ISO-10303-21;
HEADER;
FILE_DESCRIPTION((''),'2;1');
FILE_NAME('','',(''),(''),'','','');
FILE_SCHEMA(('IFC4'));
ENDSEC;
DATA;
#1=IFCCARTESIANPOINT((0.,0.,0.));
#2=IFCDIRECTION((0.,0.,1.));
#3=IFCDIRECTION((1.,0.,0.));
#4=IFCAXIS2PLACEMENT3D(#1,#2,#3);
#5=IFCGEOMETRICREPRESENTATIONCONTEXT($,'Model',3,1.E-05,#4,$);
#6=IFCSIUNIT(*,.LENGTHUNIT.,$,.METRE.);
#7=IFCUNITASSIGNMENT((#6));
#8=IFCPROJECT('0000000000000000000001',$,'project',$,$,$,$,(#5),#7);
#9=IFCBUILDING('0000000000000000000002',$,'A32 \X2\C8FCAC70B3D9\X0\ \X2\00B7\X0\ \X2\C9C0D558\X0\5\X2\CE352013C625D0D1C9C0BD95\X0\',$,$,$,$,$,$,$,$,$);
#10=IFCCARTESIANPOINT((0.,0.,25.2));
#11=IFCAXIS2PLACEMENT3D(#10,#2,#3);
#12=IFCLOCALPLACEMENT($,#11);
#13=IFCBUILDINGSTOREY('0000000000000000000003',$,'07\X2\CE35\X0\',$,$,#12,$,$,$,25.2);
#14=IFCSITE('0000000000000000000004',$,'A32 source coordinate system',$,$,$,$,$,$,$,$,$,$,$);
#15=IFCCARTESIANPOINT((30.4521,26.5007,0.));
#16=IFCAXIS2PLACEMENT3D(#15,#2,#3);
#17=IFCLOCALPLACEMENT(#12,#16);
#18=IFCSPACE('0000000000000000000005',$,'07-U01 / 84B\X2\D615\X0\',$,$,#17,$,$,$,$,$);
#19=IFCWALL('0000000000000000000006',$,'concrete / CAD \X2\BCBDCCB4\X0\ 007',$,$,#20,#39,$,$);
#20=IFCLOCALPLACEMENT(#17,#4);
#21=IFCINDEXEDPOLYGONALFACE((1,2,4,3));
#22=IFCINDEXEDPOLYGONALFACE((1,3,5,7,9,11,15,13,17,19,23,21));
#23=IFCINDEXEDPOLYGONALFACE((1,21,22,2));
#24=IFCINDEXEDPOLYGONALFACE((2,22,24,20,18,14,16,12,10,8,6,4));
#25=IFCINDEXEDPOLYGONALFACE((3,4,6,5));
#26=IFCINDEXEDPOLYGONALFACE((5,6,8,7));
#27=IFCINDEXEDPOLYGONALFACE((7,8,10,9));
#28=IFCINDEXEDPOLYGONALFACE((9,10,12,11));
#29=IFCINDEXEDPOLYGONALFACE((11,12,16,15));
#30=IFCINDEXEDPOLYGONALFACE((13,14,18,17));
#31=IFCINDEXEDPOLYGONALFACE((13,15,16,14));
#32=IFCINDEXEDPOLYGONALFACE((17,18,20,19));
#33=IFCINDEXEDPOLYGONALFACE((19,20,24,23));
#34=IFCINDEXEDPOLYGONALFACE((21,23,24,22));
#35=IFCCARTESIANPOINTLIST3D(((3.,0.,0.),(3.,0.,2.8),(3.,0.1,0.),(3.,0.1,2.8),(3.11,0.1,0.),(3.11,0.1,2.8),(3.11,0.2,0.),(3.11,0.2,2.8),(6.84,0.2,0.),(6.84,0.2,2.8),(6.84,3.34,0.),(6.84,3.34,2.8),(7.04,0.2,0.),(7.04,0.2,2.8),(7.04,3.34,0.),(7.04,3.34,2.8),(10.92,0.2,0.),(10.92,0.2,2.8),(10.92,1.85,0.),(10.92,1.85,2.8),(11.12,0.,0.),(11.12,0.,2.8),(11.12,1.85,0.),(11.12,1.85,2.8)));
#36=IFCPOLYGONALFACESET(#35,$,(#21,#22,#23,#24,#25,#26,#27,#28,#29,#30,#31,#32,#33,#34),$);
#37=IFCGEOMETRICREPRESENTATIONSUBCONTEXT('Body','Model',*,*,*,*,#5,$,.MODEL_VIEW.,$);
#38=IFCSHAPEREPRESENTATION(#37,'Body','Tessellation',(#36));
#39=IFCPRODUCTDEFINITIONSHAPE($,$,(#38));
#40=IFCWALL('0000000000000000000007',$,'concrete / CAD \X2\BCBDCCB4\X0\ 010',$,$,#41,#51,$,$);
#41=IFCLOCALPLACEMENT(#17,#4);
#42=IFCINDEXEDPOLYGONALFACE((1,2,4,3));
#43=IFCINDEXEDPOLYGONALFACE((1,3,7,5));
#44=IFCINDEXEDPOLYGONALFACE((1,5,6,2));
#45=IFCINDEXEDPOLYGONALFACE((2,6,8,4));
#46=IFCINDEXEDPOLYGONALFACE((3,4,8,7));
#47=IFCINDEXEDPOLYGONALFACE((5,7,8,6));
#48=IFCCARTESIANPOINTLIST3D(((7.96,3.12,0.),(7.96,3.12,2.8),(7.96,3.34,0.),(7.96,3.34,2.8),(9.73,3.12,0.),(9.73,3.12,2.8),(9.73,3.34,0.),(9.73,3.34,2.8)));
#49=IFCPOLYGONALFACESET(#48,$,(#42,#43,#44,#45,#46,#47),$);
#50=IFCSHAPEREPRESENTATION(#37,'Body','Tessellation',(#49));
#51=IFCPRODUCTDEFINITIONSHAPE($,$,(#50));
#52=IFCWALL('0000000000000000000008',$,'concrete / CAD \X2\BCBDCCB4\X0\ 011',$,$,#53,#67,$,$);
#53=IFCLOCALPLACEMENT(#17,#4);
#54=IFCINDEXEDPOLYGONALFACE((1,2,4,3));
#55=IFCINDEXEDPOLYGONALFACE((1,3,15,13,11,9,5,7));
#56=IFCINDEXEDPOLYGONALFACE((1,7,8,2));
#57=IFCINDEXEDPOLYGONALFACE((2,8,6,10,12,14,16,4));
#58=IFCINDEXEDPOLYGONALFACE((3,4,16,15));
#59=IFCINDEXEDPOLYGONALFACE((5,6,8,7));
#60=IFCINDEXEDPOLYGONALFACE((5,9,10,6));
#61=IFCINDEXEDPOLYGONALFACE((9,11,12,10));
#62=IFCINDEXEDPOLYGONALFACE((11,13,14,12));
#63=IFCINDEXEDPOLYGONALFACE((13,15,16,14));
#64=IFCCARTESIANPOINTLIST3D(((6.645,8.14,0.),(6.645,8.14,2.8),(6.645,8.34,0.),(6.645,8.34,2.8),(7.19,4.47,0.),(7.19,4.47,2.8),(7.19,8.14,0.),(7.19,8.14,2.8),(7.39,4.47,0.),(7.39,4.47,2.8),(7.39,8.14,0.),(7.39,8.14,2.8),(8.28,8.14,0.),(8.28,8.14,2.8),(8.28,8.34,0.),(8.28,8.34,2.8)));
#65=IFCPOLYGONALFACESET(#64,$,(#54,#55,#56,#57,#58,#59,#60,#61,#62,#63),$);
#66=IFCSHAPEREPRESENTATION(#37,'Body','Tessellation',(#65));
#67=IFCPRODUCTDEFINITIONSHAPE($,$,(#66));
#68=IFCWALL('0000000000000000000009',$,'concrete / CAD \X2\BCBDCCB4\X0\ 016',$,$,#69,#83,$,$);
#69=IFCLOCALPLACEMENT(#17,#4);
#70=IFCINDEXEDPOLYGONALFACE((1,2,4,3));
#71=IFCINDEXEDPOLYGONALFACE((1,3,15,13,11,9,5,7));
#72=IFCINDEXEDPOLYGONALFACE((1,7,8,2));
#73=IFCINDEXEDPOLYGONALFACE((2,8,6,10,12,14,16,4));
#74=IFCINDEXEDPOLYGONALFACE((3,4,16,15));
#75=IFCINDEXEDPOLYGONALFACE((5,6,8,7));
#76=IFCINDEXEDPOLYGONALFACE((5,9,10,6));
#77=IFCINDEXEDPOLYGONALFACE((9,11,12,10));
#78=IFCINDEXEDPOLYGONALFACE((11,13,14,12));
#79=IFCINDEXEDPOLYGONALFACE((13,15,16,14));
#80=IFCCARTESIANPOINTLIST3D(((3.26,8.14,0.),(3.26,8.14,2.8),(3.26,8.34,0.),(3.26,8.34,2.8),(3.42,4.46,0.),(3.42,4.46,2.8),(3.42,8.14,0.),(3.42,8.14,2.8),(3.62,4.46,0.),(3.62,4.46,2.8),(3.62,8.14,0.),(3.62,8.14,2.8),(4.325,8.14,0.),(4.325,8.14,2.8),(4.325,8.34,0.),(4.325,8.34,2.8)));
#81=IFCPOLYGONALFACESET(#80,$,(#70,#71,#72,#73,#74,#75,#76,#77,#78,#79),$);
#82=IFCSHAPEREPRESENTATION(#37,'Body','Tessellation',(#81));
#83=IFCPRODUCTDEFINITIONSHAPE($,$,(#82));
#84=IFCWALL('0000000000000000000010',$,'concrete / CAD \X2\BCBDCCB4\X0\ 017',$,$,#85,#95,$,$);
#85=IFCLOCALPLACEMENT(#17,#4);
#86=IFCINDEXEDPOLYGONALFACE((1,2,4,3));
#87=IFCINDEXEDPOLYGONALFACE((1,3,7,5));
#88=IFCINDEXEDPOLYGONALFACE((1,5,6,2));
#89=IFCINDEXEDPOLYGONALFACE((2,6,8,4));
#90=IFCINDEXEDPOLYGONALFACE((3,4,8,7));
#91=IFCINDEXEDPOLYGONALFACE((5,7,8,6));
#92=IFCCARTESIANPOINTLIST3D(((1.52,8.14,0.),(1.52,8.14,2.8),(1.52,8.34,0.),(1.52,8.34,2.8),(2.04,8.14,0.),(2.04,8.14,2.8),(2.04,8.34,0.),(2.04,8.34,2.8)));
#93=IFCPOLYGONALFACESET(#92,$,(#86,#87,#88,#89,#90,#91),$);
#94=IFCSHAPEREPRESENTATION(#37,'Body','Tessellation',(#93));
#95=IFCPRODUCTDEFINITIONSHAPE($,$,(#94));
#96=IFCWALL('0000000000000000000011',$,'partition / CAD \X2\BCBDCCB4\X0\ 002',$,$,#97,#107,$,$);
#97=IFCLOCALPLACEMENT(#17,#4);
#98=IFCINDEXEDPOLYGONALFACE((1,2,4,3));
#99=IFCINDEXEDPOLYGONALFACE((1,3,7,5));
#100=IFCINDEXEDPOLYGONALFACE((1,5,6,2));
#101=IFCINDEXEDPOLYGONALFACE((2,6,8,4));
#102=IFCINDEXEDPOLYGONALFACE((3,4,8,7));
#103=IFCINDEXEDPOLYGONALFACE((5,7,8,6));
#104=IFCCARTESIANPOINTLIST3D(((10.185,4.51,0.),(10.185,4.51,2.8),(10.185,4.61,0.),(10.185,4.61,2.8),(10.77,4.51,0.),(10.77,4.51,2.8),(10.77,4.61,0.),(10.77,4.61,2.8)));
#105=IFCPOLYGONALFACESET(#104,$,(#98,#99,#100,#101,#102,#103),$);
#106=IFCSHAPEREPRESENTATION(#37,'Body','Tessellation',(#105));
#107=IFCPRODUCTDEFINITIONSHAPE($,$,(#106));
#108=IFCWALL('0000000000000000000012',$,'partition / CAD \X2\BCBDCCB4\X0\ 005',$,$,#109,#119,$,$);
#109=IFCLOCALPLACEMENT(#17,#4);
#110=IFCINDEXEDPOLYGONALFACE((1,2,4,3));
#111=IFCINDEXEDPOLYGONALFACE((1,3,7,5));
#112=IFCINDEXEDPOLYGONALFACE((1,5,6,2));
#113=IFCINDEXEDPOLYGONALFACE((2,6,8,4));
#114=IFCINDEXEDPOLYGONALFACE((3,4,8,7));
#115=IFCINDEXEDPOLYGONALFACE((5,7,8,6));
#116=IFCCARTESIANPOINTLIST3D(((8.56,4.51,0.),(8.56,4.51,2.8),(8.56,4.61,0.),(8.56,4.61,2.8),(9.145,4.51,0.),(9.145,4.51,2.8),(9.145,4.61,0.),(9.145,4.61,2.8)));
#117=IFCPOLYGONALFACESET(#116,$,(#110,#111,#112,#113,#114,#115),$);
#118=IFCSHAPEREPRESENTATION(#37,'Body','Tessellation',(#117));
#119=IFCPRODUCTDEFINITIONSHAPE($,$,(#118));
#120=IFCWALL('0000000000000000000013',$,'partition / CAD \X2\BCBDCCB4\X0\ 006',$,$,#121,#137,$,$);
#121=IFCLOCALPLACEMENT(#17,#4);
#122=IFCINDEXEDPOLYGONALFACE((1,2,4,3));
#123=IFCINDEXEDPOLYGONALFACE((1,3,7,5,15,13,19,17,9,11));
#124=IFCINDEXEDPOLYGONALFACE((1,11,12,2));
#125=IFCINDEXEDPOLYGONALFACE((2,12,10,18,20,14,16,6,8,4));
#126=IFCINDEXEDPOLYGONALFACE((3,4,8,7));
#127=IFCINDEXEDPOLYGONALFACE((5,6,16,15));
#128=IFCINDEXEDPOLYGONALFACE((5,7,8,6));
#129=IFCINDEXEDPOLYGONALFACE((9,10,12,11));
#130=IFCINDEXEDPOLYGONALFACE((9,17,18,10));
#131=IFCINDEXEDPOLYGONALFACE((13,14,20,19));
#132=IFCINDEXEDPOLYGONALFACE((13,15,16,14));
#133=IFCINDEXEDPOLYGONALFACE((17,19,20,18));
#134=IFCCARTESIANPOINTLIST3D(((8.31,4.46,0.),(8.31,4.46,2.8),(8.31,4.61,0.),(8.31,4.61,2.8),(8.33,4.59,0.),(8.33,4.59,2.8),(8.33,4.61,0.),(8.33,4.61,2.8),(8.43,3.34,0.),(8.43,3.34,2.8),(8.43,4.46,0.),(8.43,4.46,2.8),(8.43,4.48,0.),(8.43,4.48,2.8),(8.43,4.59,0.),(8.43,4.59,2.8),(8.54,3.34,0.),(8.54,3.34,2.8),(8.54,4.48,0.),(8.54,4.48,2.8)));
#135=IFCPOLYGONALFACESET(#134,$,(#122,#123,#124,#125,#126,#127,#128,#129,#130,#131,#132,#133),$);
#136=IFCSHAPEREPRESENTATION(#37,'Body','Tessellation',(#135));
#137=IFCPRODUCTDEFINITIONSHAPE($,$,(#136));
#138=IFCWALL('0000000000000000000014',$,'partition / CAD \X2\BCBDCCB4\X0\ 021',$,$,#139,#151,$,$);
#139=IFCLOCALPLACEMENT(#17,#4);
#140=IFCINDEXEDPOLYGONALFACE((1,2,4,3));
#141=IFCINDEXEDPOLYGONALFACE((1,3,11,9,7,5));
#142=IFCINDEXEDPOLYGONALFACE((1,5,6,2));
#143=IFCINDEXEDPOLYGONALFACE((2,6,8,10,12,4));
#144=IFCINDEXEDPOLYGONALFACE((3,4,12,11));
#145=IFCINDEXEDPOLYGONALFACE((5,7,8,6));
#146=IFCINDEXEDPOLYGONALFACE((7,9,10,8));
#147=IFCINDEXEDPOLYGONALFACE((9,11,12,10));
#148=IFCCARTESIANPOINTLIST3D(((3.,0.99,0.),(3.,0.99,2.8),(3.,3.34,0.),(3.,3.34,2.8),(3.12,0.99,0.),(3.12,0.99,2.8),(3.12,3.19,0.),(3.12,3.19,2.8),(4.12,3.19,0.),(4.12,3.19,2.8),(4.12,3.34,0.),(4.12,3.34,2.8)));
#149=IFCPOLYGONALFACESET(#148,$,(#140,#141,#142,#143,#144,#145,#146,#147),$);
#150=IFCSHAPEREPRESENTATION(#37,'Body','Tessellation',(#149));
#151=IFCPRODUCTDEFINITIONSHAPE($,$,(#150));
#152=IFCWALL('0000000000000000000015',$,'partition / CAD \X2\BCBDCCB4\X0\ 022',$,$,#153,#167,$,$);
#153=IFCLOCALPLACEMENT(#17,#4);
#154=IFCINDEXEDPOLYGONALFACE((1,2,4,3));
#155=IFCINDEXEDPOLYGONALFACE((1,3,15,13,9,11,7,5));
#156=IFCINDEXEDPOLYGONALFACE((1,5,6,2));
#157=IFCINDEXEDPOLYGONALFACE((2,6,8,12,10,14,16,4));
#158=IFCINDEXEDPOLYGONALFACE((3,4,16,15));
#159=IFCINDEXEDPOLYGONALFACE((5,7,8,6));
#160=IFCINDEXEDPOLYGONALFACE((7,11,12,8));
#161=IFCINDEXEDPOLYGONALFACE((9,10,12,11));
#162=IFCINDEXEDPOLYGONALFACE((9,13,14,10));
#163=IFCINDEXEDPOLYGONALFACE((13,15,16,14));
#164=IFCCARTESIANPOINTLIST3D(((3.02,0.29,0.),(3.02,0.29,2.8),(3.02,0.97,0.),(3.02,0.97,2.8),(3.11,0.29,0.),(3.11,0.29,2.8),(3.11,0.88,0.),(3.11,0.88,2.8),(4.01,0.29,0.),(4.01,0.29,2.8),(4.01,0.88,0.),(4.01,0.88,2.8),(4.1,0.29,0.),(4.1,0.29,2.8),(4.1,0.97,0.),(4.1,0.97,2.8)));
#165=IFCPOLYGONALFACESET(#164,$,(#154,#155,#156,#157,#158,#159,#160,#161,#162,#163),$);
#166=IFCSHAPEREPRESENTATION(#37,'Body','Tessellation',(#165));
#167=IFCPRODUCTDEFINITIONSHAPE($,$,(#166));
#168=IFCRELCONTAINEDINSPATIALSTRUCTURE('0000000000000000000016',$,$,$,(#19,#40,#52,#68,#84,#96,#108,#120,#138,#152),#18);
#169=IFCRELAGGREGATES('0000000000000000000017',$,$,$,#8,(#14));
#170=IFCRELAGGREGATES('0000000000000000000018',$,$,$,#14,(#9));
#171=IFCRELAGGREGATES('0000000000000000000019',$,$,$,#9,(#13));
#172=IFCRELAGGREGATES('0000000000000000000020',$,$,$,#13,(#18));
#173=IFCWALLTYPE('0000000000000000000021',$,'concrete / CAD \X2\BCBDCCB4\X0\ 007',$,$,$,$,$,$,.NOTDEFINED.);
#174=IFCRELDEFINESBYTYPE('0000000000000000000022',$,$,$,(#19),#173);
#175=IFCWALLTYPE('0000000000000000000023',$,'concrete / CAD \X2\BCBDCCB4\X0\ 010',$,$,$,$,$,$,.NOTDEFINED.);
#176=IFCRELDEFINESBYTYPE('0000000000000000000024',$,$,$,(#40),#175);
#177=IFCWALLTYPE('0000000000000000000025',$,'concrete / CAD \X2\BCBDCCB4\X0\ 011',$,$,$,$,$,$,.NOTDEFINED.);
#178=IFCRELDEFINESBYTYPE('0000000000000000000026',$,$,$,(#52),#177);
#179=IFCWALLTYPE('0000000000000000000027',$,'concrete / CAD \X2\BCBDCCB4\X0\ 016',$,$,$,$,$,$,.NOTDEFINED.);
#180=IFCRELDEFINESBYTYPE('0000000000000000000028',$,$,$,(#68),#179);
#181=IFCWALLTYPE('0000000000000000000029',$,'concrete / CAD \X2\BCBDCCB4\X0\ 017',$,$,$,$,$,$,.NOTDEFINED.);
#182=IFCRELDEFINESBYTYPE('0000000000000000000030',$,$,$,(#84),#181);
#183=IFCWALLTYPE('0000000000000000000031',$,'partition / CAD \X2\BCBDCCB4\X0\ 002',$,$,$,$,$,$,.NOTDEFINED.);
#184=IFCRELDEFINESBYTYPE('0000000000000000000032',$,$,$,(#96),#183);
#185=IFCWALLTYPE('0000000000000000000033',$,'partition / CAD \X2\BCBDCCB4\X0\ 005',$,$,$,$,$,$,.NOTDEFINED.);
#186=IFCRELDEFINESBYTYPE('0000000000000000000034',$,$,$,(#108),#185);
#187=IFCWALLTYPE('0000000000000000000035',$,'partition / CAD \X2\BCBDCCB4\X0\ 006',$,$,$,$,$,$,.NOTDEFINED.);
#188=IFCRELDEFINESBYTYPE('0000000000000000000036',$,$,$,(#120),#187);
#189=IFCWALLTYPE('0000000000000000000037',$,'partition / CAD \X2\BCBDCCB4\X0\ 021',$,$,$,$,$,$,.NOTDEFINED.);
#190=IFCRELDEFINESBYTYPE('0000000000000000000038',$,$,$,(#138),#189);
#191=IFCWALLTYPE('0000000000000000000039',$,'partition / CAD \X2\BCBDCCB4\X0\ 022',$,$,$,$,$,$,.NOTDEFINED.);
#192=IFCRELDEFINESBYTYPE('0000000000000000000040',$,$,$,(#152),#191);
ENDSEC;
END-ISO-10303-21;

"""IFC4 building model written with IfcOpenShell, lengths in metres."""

from ifc_helpers import new_model, si_unit, frame, origin, origin_with_axes, place, context, subcontext, project, spatial, polyline, outline, extrude, source, transform, mapped, type_object, type_shapes, element, save


model = new_model("IFC4")

# Units and contexts
model_context = context("Model", 3, precision=1e-05, world=origin_with_axes())
body_context = subcontext(model_context, "Body", "Model", "MODEL_VIEW")
ifc_project = project(units=[si_unit("LENGTHUNIT", "METRE")], contexts=[model_context])

# Site, building, storey, space
site = spatial("IfcSite", under=ifc_project, Name="A32 source coordinate system")
building = spatial("IfcBuilding", under=site, Name="A32 주거동 · 지하5층–옥탑지붕")
storey_placement = place(None, frame((0.0, 0.0, 25.2), z_axis=(0.0, 0.0, 1.0), x_axis=(1.0, 0.0, 0.0)))
storey = spatial("IfcBuildingStorey", under=building, at=storey_placement, Name="07층", Elevation=25.2)
space_1_placement = place(storey_placement, frame((30.4521, 26.5007, 0.0), z_axis=(0.0, 0.0, 1.0), x_axis=(1.0, 0.0, 0.0)))
space_1 = spatial("IfcSpace", under=storey, at=space_1_placement, Name="07-U01 / 84B형")

# Walls
wall_type_1 = type_object("IfcWallType", Name="concrete / CAD 벽체 007", PredefinedType="NOTDEFINED")
shared_shape_1 = source(origin(), body_context, "Body", "SweptSolid", [
    extrude(outline(polyline([(3.0, 0.0), (3.0, 0.1), (3.11, 0.1), (3.11, 0.2), (6.84, 0.2), (6.84, 3.34), (7.04, 3.34), (7.04, 0.2), (10.92, 0.2), (10.92, 1.85), (11.12, 1.85), (11.12, 0.0), (3.0, 0.0)])), origin(), (0.0, 0.0, 1.0), 2.8),
])
type_shapes(wall_type_1, [shared_shape_1])
wall_1_placement = place(space_1_placement, origin_with_axes())
element("IfcWall", 1, at=wall_1_placement, inside=space_1, type_object=wall_type_1, Name="concrete / CAD 벽체 007", context=body_context, shape_type="MappedRepresentation", body=[
    mapped(shared_shape_1, transform((0.0, 0.0, 0.0), scale=1.0)),
])
wall_type_2 = type_object("IfcWallType", Name="concrete / CAD 벽체 010", PredefinedType="NOTDEFINED")
shared_shape_2 = source(origin(), body_context, "Body", "SweptSolid", [
    extrude(outline(polyline([(7.96, 3.12), (7.96, 3.34), (9.73, 3.34), (9.73, 3.12), (7.96, 3.12)])), origin(), (0.0, 0.0, 1.0), 2.8),
])
type_shapes(wall_type_2, [shared_shape_2])
wall_2_placement = place(space_1_placement, origin_with_axes())
element("IfcWall", 2, at=wall_2_placement, inside=space_1, type_object=wall_type_2, Name="concrete / CAD 벽체 010", context=body_context, shape_type="MappedRepresentation", body=[
    mapped(shared_shape_2, transform((0.0, 0.0, 0.0), scale=1.0)),
])
wall_type_3 = type_object("IfcWallType", Name="concrete / CAD 벽체 011", PredefinedType="NOTDEFINED")
shared_shape_3 = source(origin(), body_context, "Body", "SweptSolid", [
    extrude(outline(polyline([(7.19, 8.14), (6.645, 8.14), (6.645, 8.34), (8.28, 8.34), (8.28, 8.14), (7.39, 8.14), (7.39, 4.47), (7.19, 4.47), (7.19, 8.14)])), origin(), (0.0, 0.0, 1.0), 2.8),
])
type_shapes(wall_type_3, [shared_shape_3])
wall_3_placement = place(space_1_placement, origin_with_axes())
element("IfcWall", 3, at=wall_3_placement, inside=space_1, type_object=wall_type_3, Name="concrete / CAD 벽체 011", context=body_context, shape_type="MappedRepresentation", body=[
    mapped(shared_shape_3, transform((0.0, 0.0, 0.0), scale=1.0)),
])
wall_type_4 = type_object("IfcWallType", Name="concrete / CAD 벽체 016", PredefinedType="NOTDEFINED")
shared_shape_4 = source(origin(), body_context, "Body", "SweptSolid", [
    extrude(outline(polyline([(3.26, 8.14), (3.26, 8.34), (4.325, 8.34), (4.325, 8.14), (3.62, 8.14), (3.62, 4.46), (3.42, 4.46), (3.42, 8.14), (3.26, 8.14)])), origin(), (0.0, 0.0, 1.0), 2.8),
])
type_shapes(wall_type_4, [shared_shape_4])
wall_4_placement = place(space_1_placement, origin_with_axes())
element("IfcWall", 4, at=wall_4_placement, inside=space_1, type_object=wall_type_4, Name="concrete / CAD 벽체 016", context=body_context, shape_type="MappedRepresentation", body=[
    mapped(shared_shape_4, transform((0.0, 0.0, 0.0), scale=1.0)),
])
wall_type_5 = type_object("IfcWallType", Name="concrete / CAD 벽체 017", PredefinedType="NOTDEFINED")
shared_shape_5 = source(origin(), body_context, "Body", "SweptSolid", [
    extrude(outline(polyline([(1.52, 8.34), (2.04, 8.34), (2.04, 8.14), (1.52, 8.14), (1.52, 8.34)])), origin(), (0.0, 0.0, 1.0), 2.8),
])
type_shapes(wall_type_5, [shared_shape_5])
wall_5_placement = place(space_1_placement, origin_with_axes())
element("IfcWall", 5, at=wall_5_placement, inside=space_1, type_object=wall_type_5, Name="concrete / CAD 벽체 017", context=body_context, shape_type="MappedRepresentation", body=[
    mapped(shared_shape_5, transform((0.0, 0.0, 0.0), scale=1.0)),
])
wall_type_6 = type_object("IfcWallType", Name="partition / CAD 벽체 002", PredefinedType="NOTDEFINED")
shared_shape_6 = source(origin(), body_context, "Body", "SweptSolid", [
    extrude(outline(polyline([(10.185, 4.51), (10.185, 4.61), (10.77, 4.61), (10.77, 4.51), (10.185, 4.51)])), origin(), (0.0, 0.0, 1.0), 2.8),
])
type_shapes(wall_type_6, [shared_shape_6])
wall_6_placement = place(space_1_placement, origin_with_axes())
element("IfcWall", 6, at=wall_6_placement, inside=space_1, type_object=wall_type_6, Name="partition / CAD 벽체 002", context=body_context, shape_type="MappedRepresentation", body=[
    mapped(shared_shape_6, transform((0.0, 0.0, 0.0), scale=1.0)),
])
wall_type_7 = type_object("IfcWallType", Name="partition / CAD 벽체 005", PredefinedType="NOTDEFINED")
shared_shape_7 = source(origin(), body_context, "Body", "SweptSolid", [
    extrude(outline(polyline([(8.56, 4.51), (8.56, 4.61), (9.145, 4.61), (9.145, 4.51), (8.56, 4.51)])), origin(), (0.0, 0.0, 1.0), 2.8),
])
type_shapes(wall_type_7, [shared_shape_7])
wall_7_placement = place(space_1_placement, origin_with_axes())
element("IfcWall", 7, at=wall_7_placement, inside=space_1, type_object=wall_type_7, Name="partition / CAD 벽체 005", context=body_context, shape_type="MappedRepresentation", body=[
    mapped(shared_shape_7, transform((0.0, 0.0, 0.0), scale=1.0)),
])
wall_type_8 = type_object("IfcWallType", Name="partition / CAD 벽체 006", PredefinedType="NOTDEFINED")
shared_shape_8 = source(origin(), body_context, "Body", "SweptSolid", [
    extrude(outline(polyline([(8.43, 4.46), (8.31, 4.46), (8.31, 4.61), (8.33, 4.61), (8.33, 4.59), (8.43, 4.59), (8.43, 4.48), (8.54, 4.48), (8.54, 3.34), (8.43, 3.34), (8.43, 4.46)])), origin(), (0.0, 0.0, 1.0), 2.8),
])
type_shapes(wall_type_8, [shared_shape_8])
wall_8_placement = place(space_1_placement, origin_with_axes())
element("IfcWall", 8, at=wall_8_placement, inside=space_1, type_object=wall_type_8, Name="partition / CAD 벽체 006", context=body_context, shape_type="MappedRepresentation", body=[
    mapped(shared_shape_8, transform((0.0, 0.0, 0.0), scale=1.0)),
])
wall_type_9 = type_object("IfcWallType", Name="partition / CAD 벽체 021", PredefinedType="NOTDEFINED")
shared_shape_9 = source(origin(), body_context, "Body", "SweptSolid", [
    extrude(outline(polyline([(4.12, 3.34), (4.12, 3.19), (3.12, 3.19), (3.12, 0.99), (3.0, 0.99), (3.0, 3.34), (4.12, 3.34)])), origin(), (0.0, 0.0, 1.0), 2.8),
])
type_shapes(wall_type_9, [shared_shape_9])
wall_9_placement = place(space_1_placement, origin_with_axes())
element("IfcWall", 9, at=wall_9_placement, inside=space_1, type_object=wall_type_9, Name="partition / CAD 벽체 021", context=body_context, shape_type="MappedRepresentation", body=[
    mapped(shared_shape_9, transform((0.0, 0.0, 0.0), scale=1.0)),
])
wall_type_10 = type_object("IfcWallType", Name="partition / CAD 벽체 022", PredefinedType="NOTDEFINED")
shared_shape_10 = source(origin(), body_context, "Body", "SweptSolid", [
    extrude(outline(polyline([(4.1, 0.97), (4.1, 0.29), (4.01, 0.29), (4.01, 0.88), (3.11, 0.88), (3.11, 0.29), (3.02, 0.29), (3.02, 0.97), (4.1, 0.97)])), origin(), (0.0, 0.0, 1.0), 2.8),
])
type_shapes(wall_type_10, [shared_shape_10])
wall_10_placement = place(space_1_placement, origin_with_axes())
element("IfcWall", 10, at=wall_10_placement, inside=space_1, type_object=wall_type_10, Name="partition / CAD 벽체 022", context=body_context, shape_type="MappedRepresentation", body=[
    mapped(shared_shape_10, transform((0.0, 0.0, 0.0), scale=1.0)),
])

save(model, "model.ifc")
